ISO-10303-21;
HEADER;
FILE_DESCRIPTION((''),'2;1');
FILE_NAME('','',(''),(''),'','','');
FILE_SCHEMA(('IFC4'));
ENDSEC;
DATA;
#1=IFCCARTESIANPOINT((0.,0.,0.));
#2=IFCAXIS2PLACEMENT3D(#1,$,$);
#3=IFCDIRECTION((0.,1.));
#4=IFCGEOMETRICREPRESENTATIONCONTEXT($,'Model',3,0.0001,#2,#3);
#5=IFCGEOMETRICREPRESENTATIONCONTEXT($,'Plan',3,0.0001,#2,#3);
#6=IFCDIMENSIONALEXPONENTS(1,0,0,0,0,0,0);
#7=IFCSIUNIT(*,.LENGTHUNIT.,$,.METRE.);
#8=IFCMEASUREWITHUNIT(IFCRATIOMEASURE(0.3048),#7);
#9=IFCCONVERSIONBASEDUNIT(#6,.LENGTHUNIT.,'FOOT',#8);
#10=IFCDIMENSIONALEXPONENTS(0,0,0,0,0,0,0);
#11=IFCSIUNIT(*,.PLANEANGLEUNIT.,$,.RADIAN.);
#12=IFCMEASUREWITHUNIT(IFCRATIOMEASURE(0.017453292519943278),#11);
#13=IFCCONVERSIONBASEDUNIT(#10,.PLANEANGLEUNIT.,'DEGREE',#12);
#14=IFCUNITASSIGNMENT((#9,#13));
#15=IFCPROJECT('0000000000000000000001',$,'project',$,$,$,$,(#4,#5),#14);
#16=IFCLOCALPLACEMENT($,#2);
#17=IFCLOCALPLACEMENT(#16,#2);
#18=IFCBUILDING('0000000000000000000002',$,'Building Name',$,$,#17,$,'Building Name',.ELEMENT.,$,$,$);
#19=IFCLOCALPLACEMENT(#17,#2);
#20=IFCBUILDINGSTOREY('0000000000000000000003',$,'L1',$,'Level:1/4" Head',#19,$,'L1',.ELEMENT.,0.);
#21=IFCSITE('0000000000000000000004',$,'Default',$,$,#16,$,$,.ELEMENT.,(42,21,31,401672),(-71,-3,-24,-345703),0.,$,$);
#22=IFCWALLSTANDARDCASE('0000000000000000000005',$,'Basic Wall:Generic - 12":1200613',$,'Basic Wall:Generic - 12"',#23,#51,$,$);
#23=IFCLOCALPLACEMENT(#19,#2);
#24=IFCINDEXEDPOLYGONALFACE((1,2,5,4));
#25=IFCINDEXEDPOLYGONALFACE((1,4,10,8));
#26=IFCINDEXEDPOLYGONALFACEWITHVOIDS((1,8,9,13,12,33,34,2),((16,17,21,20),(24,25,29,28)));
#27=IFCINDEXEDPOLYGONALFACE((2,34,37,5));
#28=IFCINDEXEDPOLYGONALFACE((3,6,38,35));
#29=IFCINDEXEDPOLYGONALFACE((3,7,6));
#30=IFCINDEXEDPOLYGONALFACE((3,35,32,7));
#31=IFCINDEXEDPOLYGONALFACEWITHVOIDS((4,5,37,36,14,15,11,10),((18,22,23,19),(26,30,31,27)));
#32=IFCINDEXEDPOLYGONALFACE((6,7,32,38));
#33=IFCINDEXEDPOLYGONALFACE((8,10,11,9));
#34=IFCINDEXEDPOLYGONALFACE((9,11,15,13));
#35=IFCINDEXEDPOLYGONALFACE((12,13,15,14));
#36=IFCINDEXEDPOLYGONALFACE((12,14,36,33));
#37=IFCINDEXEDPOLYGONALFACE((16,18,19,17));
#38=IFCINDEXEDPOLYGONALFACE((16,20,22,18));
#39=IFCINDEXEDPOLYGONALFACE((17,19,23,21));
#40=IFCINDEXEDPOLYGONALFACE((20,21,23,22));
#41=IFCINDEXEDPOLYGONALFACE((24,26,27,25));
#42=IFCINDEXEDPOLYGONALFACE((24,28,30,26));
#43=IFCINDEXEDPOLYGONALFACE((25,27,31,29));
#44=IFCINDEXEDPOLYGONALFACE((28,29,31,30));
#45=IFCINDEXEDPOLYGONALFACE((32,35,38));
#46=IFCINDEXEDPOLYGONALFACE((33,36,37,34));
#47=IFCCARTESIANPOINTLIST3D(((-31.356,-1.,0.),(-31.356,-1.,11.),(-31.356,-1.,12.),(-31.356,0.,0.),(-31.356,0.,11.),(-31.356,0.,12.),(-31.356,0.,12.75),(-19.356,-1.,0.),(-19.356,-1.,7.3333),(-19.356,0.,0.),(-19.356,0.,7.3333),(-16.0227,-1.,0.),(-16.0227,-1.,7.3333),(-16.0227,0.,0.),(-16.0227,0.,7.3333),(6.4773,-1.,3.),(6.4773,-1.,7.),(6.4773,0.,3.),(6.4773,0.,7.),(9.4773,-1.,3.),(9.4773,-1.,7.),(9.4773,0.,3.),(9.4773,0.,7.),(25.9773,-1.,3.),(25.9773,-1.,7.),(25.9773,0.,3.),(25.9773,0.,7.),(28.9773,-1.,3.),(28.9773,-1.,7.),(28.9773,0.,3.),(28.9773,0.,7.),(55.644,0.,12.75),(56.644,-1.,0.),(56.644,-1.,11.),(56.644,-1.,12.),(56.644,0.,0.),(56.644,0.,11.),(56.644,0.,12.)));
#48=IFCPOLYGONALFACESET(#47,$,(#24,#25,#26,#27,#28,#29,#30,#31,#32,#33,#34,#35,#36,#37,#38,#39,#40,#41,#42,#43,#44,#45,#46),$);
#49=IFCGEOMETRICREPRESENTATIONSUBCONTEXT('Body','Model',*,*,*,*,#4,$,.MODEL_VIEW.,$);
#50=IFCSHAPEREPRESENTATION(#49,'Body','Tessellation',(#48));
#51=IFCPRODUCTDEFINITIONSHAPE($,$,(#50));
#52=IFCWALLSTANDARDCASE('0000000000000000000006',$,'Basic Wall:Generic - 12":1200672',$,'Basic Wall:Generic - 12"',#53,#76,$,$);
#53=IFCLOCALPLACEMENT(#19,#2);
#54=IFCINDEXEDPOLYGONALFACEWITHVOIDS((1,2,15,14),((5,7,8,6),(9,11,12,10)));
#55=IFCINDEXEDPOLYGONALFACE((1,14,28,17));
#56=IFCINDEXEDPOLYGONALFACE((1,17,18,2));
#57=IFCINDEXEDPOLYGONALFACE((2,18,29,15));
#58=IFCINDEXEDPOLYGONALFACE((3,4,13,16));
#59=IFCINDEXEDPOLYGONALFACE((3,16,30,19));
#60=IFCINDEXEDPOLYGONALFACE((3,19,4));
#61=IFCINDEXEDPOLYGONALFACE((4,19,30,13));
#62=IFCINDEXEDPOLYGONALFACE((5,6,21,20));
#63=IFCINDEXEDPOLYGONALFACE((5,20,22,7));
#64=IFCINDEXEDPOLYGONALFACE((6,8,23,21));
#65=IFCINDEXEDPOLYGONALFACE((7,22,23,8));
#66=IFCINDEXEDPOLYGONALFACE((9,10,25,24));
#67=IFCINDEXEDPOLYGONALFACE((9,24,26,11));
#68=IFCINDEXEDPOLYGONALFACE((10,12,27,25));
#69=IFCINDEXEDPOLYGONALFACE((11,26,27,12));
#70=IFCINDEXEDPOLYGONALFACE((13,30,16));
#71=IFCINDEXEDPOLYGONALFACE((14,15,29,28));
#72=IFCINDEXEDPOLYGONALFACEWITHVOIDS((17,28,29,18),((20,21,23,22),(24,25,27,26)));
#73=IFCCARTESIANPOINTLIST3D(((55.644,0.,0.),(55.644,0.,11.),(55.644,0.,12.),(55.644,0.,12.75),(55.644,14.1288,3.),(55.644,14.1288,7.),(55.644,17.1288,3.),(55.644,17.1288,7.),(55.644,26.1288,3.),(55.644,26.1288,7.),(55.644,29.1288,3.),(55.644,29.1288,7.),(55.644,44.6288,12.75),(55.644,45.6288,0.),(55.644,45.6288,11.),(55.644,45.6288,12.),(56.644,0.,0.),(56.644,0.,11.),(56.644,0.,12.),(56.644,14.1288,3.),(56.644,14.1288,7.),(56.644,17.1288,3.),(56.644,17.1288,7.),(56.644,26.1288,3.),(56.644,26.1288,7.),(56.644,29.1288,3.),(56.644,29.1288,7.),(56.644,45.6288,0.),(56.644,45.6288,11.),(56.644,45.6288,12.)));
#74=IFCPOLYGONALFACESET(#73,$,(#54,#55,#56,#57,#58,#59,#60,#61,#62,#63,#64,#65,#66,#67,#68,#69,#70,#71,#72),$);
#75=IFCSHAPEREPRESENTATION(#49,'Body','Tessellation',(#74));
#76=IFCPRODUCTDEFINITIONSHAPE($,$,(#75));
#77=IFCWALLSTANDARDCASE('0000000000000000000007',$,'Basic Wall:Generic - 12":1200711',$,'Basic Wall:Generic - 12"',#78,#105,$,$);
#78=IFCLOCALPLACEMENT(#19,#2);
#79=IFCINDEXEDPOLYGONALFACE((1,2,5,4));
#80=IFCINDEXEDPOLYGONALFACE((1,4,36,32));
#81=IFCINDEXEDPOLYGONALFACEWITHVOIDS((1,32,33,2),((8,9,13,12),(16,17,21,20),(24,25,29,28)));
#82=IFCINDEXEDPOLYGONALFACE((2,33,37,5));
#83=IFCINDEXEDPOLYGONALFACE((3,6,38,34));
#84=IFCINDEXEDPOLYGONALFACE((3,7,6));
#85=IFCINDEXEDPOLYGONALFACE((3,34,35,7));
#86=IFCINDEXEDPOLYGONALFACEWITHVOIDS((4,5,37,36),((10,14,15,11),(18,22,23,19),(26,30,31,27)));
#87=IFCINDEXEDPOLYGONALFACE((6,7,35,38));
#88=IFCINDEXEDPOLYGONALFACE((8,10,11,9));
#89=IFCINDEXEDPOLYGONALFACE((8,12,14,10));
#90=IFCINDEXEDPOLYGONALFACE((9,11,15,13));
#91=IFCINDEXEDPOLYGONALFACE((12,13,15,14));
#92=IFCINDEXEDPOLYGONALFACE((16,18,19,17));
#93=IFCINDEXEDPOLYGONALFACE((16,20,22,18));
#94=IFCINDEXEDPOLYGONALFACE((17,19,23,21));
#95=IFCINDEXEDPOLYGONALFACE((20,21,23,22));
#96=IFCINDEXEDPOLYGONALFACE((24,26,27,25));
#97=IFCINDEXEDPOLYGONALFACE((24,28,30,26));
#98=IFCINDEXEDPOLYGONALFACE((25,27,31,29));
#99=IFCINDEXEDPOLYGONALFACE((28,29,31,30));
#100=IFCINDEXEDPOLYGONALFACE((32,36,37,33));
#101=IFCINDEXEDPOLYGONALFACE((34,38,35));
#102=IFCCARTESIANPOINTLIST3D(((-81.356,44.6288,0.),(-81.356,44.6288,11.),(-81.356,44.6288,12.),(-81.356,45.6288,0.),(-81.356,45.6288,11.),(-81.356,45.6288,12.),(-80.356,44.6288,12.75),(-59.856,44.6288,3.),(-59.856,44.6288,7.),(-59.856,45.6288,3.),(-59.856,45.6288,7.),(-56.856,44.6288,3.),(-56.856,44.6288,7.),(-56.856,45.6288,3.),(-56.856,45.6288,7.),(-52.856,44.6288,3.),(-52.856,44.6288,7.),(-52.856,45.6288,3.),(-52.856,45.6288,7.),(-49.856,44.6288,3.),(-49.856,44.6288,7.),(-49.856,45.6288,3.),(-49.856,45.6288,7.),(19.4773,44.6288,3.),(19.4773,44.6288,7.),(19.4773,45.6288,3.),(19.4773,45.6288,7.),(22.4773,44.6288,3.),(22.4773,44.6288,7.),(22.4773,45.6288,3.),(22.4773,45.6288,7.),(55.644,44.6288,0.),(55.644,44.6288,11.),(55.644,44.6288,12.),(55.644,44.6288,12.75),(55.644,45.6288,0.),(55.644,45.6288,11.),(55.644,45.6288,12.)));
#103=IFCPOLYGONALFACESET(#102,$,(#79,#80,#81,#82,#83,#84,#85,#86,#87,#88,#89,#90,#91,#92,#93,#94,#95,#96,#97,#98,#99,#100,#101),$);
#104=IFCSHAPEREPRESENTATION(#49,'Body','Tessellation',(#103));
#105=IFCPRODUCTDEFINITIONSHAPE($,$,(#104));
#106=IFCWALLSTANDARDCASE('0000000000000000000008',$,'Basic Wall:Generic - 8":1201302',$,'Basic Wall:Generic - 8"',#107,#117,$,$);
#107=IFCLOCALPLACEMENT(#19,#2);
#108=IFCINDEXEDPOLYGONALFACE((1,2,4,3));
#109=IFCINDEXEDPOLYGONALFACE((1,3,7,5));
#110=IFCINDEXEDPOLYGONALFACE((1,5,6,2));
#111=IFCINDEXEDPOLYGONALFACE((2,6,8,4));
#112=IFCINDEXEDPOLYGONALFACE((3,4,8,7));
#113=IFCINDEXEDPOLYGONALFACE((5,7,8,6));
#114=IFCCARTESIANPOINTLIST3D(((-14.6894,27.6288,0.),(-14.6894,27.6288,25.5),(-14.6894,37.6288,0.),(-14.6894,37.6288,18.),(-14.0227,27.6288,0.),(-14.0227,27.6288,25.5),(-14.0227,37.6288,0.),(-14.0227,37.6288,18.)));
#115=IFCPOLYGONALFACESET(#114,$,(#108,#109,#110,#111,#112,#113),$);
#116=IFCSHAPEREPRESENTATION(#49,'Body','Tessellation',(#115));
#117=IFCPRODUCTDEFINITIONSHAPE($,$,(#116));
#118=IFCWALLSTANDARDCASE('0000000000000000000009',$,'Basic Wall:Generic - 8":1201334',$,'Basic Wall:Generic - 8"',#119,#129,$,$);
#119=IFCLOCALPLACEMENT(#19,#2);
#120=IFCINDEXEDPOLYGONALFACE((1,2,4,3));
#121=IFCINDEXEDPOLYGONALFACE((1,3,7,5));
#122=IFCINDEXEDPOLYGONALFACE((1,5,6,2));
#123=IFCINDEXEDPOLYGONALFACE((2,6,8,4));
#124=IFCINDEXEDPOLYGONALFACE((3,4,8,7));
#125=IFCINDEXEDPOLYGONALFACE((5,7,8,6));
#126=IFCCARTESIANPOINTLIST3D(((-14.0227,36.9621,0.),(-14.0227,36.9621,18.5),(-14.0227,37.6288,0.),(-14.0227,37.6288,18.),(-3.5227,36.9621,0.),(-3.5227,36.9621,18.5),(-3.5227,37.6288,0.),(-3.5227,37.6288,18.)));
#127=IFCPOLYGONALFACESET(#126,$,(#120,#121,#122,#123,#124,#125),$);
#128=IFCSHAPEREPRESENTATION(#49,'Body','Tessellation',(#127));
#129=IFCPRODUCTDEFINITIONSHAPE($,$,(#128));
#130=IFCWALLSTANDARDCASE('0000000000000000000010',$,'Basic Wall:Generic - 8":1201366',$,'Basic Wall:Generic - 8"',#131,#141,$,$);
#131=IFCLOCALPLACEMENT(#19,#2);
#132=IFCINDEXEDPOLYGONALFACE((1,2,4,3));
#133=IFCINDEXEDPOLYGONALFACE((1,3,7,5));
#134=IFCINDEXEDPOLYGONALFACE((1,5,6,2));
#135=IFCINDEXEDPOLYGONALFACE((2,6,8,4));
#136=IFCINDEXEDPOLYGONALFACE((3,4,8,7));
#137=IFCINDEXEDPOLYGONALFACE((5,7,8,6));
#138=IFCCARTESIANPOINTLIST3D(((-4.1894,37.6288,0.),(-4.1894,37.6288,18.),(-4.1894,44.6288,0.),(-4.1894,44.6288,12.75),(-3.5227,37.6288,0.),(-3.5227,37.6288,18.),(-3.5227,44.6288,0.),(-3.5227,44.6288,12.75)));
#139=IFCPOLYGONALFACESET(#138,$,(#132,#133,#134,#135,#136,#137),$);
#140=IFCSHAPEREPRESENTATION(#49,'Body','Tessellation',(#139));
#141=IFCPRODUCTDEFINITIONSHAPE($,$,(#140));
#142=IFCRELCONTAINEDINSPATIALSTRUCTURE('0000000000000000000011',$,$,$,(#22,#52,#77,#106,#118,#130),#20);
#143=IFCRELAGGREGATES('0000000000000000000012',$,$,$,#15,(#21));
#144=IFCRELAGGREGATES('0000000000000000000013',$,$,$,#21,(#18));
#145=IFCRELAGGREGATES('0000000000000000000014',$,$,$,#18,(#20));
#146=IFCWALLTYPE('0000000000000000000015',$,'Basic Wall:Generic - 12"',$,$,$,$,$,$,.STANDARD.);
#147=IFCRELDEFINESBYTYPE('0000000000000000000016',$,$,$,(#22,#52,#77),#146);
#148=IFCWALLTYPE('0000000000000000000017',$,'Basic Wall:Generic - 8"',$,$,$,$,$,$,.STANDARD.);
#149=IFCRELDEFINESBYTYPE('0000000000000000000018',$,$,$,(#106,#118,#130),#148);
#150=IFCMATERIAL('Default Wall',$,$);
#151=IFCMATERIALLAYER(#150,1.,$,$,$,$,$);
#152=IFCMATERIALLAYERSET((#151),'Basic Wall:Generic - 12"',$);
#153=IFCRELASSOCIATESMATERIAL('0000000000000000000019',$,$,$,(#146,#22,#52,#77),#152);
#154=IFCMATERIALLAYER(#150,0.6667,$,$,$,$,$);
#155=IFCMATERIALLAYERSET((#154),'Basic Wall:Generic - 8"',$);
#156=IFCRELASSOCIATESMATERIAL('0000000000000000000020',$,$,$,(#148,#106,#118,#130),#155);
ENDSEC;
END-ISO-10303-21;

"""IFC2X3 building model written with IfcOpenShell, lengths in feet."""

from ifc_helpers import new_model, entity, si_unit, converted_unit, direction, frame, frame_2d, origin, place, context, subcontext, project, spatial, polyline, rectangle, extrude, clip, bounded_halfspace, material, layer, layer_set, layer_usage, type_object, element, save


model = new_model("IFC2X3")

# Units and contexts
model_context = context("Model", 3, precision=0.0001, world=origin(), true_north=direction((0.0, 1.0)))
plan_context = context("Plan", 3, precision=0.0001, world=origin(), true_north=direction((0.0, 1.0)))
body_context = subcontext(model_context, "Body", "Model", "MODEL_VIEW")
ifc_project = project(units=[converted_unit("LENGTHUNIT", "FOOT", entity("IfcRatioMeasure", 0.3048), si_unit("LENGTHUNIT", "METRE"), dimensions=[1, 0, 0, 0, 0, 0, 0]), converted_unit("PLANEANGLEUNIT", "DEGREE", entity("IfcRatioMeasure", 0.017453292519943278), si_unit("PLANEANGLEUNIT", "RADIAN"), dimensions=[0, 0, 0, 0, 0, 0, 0])], contexts=[model_context, plan_context])

# Site, building, storey
site_placement = place(None, origin())
site = spatial("IfcSite", under=ifc_project, at=site_placement, Name="Default", CompositionType="ELEMENT", RefLatitude=(42, 21, 31, 401672), RefLongitude=(-71, -3, -24, -345703), RefElevation=0.0)
building_placement = place(site_placement, origin())
building = spatial("IfcBuilding", under=site, at=building_placement, Name="Building Name", LongName="Building Name", CompositionType="ELEMENT")
storey_placement = place(building_placement, origin())
storey = spatial("IfcBuildingStorey", under=building, at=storey_placement, Name="L1", ObjectType="Level:1/4\" Head", LongName="L1", CompositionType="ELEMENT", Elevation=0.0)

# Walls, openings
ifc_material_1 = material(Name="Default Wall")
ifc_layer_1 = layer(ifc_material_1, 1.0)
ifc_layer_set_1 = layer_set([ifc_layer_1], Name="Basic Wall:Generic - 12\"")
ifc_layer_usage_1 = layer_usage(ifc_layer_set_1, "AXIS2", "NEGATIVE", 0.5)
wall_type_1 = type_object("IfcWallType", Name="Basic Wall:Generic - 12\"", PredefinedType="STANDARD", material=ifc_layer_set_1)
wall_1_placement = place(storey_placement, frame((-31.356, -0.5, 0.0)))
wall_1 = element("IfcWallStandardCase", 1, at=wall_1_placement, inside=storey, type_object=wall_type_1, material=ifc_layer_usage_1, Name="Basic Wall:Generic - 12\":1200613", ObjectType="Basic Wall:Generic - 12\"", context=body_context, shape_type="Clipping", body=[
    clip(clip(extrude(rectangle(XDim=1.0, YDim=88.0, at=frame_2d((44.0, 0.0), x_axis=(0.0, 1.0))), origin(), (0.0, 0.0, 1.0), 12.75), bounded_halfspace(frame((0.0, 0.5, 12.75), z_axis=(0.0, -0.6, 0.8), x_axis=(1.0, 0.0, 0.0)), False, frame((0.0, 0.5, 12.75)), polyline([(0.0, 0.0), (0.0, -1.0), (88.0, -1.0), (87.0, 0.0), (0.0, 0.0)]))), bounded_halfspace(frame((88.0, 0.5, 12.0), z_axis=(0.6, 0.0, 0.8), x_axis=(0.0, 1.0, 0.0)), False, frame((88.0, 0.5, 12.0)), polyline([(0.0, 0.0), (-1.0, 0.0), (0.0, -1.0), (0.0, 0.0)]))),
])
opening_1_placement = place(storey_placement, frame((-31.356, -0.5, 0.0)))
element("IfcOpeningElement", 2, at=opening_1_placement, cuts=wall_1, ObjectType="Opening", context=body_context, shape_type="SweptSolid", body=[
    extrude(rectangle(XDim=88.0, YDim=1.0, at=frame_2d((-8.6, -0.1), x_axis=(1.0, 0.0))), frame((52.6, 0.1, 11.0)), (0.0, 0.0, 1.0), 1.0),
])
opening_2_placement = place(wall_1_placement, frame((12.0, -0.5, 0.0)))
element("IfcOpeningElement", 3, at=opening_2_placement, cuts=wall_1, ObjectType="Opening", context=body_context, shape_type="SweptSolid", body=[
    extrude(rectangle(XDim=7.3333, YDim=3.3333, at=frame_2d((3.6667, 1.6667), x_axis=(1.0, 0.0))), frame((0.0, 0.0, 0.0), z_axis=(0.0, 1.0, 0.0), x_axis=(0.0, 0.0, 1.0)), (0.0, 0.0, 1.0), 1.0),
])
opening_3_placement = place(wall_1_placement, frame((37.8333, -0.5, 3.0)))
element("IfcOpeningElement", 4, at=opening_3_placement, cuts=wall_1, ObjectType="Opening", context=body_context, shape_type="SweptSolid", body=[
    extrude(rectangle(XDim=4.0, YDim=3.0, at=frame_2d((2.0, 1.5), x_axis=(-1.0, 0.0))), frame((0.0, 0.0, 0.0), z_axis=(0.0, 1.0, 0.0), x_axis=(0.0, 0.0, 1.0)), (0.0, 0.0, 1.0), 1.0),
])
opening_4_placement = place(wall_1_placement, frame((60.3333, 0.5, 3.0)))
element("IfcOpeningElement", 5, at=opening_4_placement, cuts=wall_1, ObjectType="Opening", context=body_context, shape_type="SweptSolid", body=[
    extrude(rectangle(XDim=4.0, YDim=3.0, at=frame_2d((2.0, 1.5), x_axis=(-1.0, 0.0))), frame((0.0, 0.0, 0.0), z_axis=(0.0, -1.0, 0.0), x_axis=(0.0, 0.0, 1.0)), (0.0, 0.0, 1.0), 1.0),
])
wall_2_placement = place(storey_placement, frame((56.144, 0.0, 0.0), z_axis=(0.0, 0.0, 1.0), x_axis=(0.0, 1.0, 0.0)))
wall_2 = element("IfcWallStandardCase", 6, at=wall_2_placement, inside=storey, type_object=wall_type_1, material=ifc_layer_usage_1, Name="Basic Wall:Generic - 12\":1200672", ObjectType="Basic Wall:Generic - 12\"", context=body_context, shape_type="Clipping", body=[
    clip(clip(extrude(rectangle(XDim=45.6288, YDim=1.0, at=frame_2d((22.8144, 0.0), x_axis=(-1.0, 0.0))), origin(), (0.0, 0.0, 1.0), 12.75), bounded_halfspace(frame((0.0, 0.5, 12.75), z_axis=(0.0, -0.6, 0.8), x_axis=(1.0, 0.0, 0.0)), False, frame((0.0, 0.5, 12.75)), polyline([(0.0, 0.0), (0.0, -1.0), (45.6288, -1.0), (44.6288, 0.0), (0.0, 0.0)]))), bounded_halfspace(frame((45.6288, 0.5, 12.0), z_axis=(0.6, 0.0, 0.8), x_axis=(0.0, 1.0, 0.0)), False, frame((45.6288, 0.5, 12.0)), polyline([(0.0, 0.0), (-1.0, 0.0), (0.0, -1.0), (0.0, 0.0)]))),
])
opening_5_placement = place(storey_placement, frame((56.144, 0.0, 0.0), z_axis=(0.0, 0.0, 1.0), x_axis=(0.0, 1.0, 0.0)))
element("IfcOpeningElement", 7, at=opening_5_placement, cuts=wall_2, ObjectType="Opening", context=body_context, shape_type="SweptSolid", body=[
    extrude(rectangle(XDim=45.6288, YDim=1.0, at=frame_2d((-4.3629, -0.1), x_axis=(1.0, 0.0))), frame((27.1773, 0.1, 11.0)), (0.0, 0.0, 1.0), 1.0),
])
opening_6_placement = place(wall_2_placement, frame((29.1288, 0.5, 3.0)))
element("IfcOpeningElement", 8, at=opening_6_placement, cuts=wall_2, ObjectType="Opening", context=body_context, shape_type="SweptSolid", body=[
    extrude(rectangle(XDim=4.0, YDim=3.0, at=frame_2d((2.0, 1.5), x_axis=(-1.0, 0.0))), frame((0.0, 0.0, 0.0), z_axis=(0.0, -1.0, 0.0), x_axis=(0.0, 0.0, 1.0)), (0.0, 0.0, 1.0), 1.0),
])
opening_7_placement = place(wall_2_placement, frame((14.1288, -0.5, 3.0)))
element("IfcOpeningElement", 9, at=opening_7_placement, cuts=wall_2, ObjectType="Opening", context=body_context, shape_type="SweptSolid", body=[
    extrude(rectangle(XDim=4.0, YDim=3.0, at=frame_2d((2.0, 1.5), x_axis=(-1.0, 0.0))), frame((0.0, 0.0, 0.0), z_axis=(0.0, 1.0, 0.0), x_axis=(0.0, 0.0, 1.0)), (0.0, 0.0, 1.0), 1.0),
])
wall_3_placement = place(storey_placement, frame((55.644, 45.1288, 0.0), z_axis=(0.0, 0.0, 1.0), x_axis=(-1.0, 0.0, 0.0)))
wall_3 = element("IfcWallStandardCase", 10, at=wall_3_placement, inside=storey, type_object=wall_type_1, material=ifc_layer_usage_1, Name="Basic Wall:Generic - 12\":1200711", ObjectType="Basic Wall:Generic - 12\"", context=body_context, shape_type="Clipping", body=[
    clip(clip(extrude(rectangle(XDim=137.0, YDim=1.0, at=frame_2d((68.5, 0.0), x_axis=(-1.0, 0.0))), origin(), (0.0, 0.0, 1.0), 12.75), bounded_halfspace(frame((137.0, 0.5, 12.0), z_axis=(0.6, 0.0, 0.8), x_axis=(0.0, 1.0, 0.0)), False, frame((137.0, 0.5, 12.0)), polyline([(0.0, 0.0), (-1.0, 0.0), (0.0, -1.0), (0.0, 0.0)]))), bounded_halfspace(frame((0.0, 0.5, 12.75), z_axis=(0.0, -0.6, 0.8), x_axis=(1.0, 0.0, 0.0)), False, frame((0.0, 0.5, 12.75)), polyline([(0.0, 0.0), (0.0, -1.0), (137.0, -1.0), (136.0, 0.0), (88.0, 0.0), (87.3333, 0.0), (59.8333, 0.0), (59.1667, 0.0), (0.0, 0.0)]))),
])
opening_8_placement = place(storey_placement, frame((55.644, 45.1288, 0.0), z_axis=(0.0, 0.0, 1.0), x_axis=(-1.0, 0.0, 0.0)))
element("IfcOpeningElement", 11, at=opening_8_placement, cuts=wall_3, ObjectType="Opening", context=body_context, shape_type="SweptSolid", body=[
    extrude(rectangle(XDim=137.0, YDim=1.0, at=frame_2d((-13.5, -0.1), x_axis=(1.0, 0.0))), frame((82.0, 0.1, 11.0)), (0.0, 0.0, 1.0), 1.0),
])
opening_9_placement = place(wall_3_placement, frame((33.1667, -0.5, 3.0)))
element("IfcOpeningElement", 12, at=opening_9_placement, cuts=wall_3, ObjectType="Opening", context=body_context, shape_type="SweptSolid", body=[
    extrude(rectangle(XDim=4.0, YDim=3.0, at=frame_2d((2.0, 1.5), x_axis=(-1.0, 0.0))), frame((0.0, 0.0, 0.0), z_axis=(0.0, 1.0, 0.0), x_axis=(0.0, 0.0, 1.0)), (0.0, 0.0, 1.0), 1.0),
])
opening_10_placement = place(wall_3_placement, frame((105.5, -0.5, 3.0)))
element("IfcOpeningElement", 13, at=opening_10_placement, cuts=wall_3, ObjectType="Opening", context=body_context, shape_type="SweptSolid", body=[
    extrude(rectangle(XDim=4.0, YDim=3.0, at=frame_2d((2.0, 1.5), x_axis=(-1.0, 0.0))), frame((0.0, 0.0, 0.0), z_axis=(0.0, 1.0, 0.0), x_axis=(0.0, 0.0, 1.0)), (0.0, 0.0, 1.0), 1.0),
])
opening_11_placement = place(wall_3_placement, frame((112.5, -0.5, 3.0)))
element("IfcOpeningElement", 14, at=opening_11_placement, cuts=wall_3, ObjectType="Opening", context=body_context, shape_type="SweptSolid", body=[
    extrude(rectangle(XDim=4.0, YDim=3.0, at=frame_2d((2.0, 1.5), x_axis=(-1.0, 0.0))), frame((0.0, 0.0, 0.0), z_axis=(0.0, 1.0, 0.0), x_axis=(0.0, 0.0, 1.0)), (0.0, 0.0, 1.0), 1.0),
])

# Walls
ifc_layer_2 = layer(ifc_material_1, 0.6667)
ifc_layer_set_2 = layer_set([ifc_layer_2], Name="Basic Wall:Generic - 8\"")
ifc_layer_usage_2 = layer_usage(ifc_layer_set_2, "AXIS2", "NEGATIVE", 0.3333)
wall_type_2 = type_object("IfcWallType", Name="Basic Wall:Generic - 8\"", PredefinedType="STANDARD", material=ifc_layer_set_2)
wall_4_placement = place(storey_placement, frame((-14.356, 27.6288, 0.0), z_axis=(0.0, 0.0, 1.0), x_axis=(0.0, 1.0, 0.0)))
element("IfcWallStandardCase", 15, at=wall_4_placement, inside=storey, type_object=wall_type_2, material=ifc_layer_usage_2, Name="Basic Wall:Generic - 8\":1201302", ObjectType="Basic Wall:Generic - 8\"", context=body_context, shape_type="Clipping", body=[
    clip(extrude(rectangle(XDim=10.0, YDim=0.6667, at=frame_2d((5.0, 0.0), x_axis=(-1.0, 0.0))), origin(), (0.0, 0.0, 1.0), 25.5), bounded_halfspace(frame((0.0, -0.3333, 25.5), z_axis=(0.6, 0.0, 0.8), x_axis=(0.0, 1.0, 0.0)), False, frame((0.0, -0.3333, 25.5)), polyline([(0.0, 0.0), (9.3333, 0.0), (10.0, 0.0), (10.0, 0.6667), (0.0, 0.6667), (0.0, 0.0)]))),
])
wall_5_placement = place(storey_placement, frame((-14.0227, 37.2955, 0.0)))
element("IfcWallStandardCase", 16, at=wall_5_placement, inside=storey, type_object=wall_type_2, material=ifc_layer_usage_2, Name="Basic Wall:Generic - 8\":1201334", ObjectType="Basic Wall:Generic - 8\"", context=body_context, shape_type="Clipping", body=[
    clip(extrude(rectangle(XDim=10.5, YDim=0.6667, at=frame_2d((5.25, 0.0), x_axis=(-1.0, 0.0))), origin(), (0.0, 0.0, 1.0), 18.5), bounded_halfspace(frame((0.0, -0.3333, 18.5), z_axis=(0.0, 0.6, 0.8), x_axis=(-1.0, 0.0, 0.0)), False, frame((0.0, -0.3333, 18.5)), polyline([(0.0, 0.0), (10.5, 0.0), (10.5, 0.6667), (9.8333, 0.6667), (0.0, 0.6667), (0.0, 0.0)]))),
])
wall_6_placement = place(storey_placement, frame((-3.856, 37.6288, 0.0), z_axis=(0.0, 0.0, 1.0), x_axis=(0.0, 1.0, 0.0)))
element("IfcWallStandardCase", 17, at=wall_6_placement, inside=storey, type_object=wall_type_2, material=ifc_layer_usage_2, Name="Basic Wall:Generic - 8\":1201366", ObjectType="Basic Wall:Generic - 8\"", context=body_context, shape_type="Clipping", body=[
    clip(extrude(rectangle(XDim=7.0, YDim=0.6667, at=frame_2d((3.5, 0.0), x_axis=(-1.0, 0.0))), origin(), (0.0, 0.0, 1.0), 18.0), bounded_halfspace(frame((0.0, -0.3333, 18.0), z_axis=(0.6, 0.0, 0.8), x_axis=(0.0, 1.0, 0.0)), False, frame((0.0, -0.3333, 18.0)), polyline([(0.0, 0.0), (7.0, 0.0), (7.0, 0.6667), (0.0, 0.6667), (0.0, 0.0)]))),
])

save(model, "model.ifc")
